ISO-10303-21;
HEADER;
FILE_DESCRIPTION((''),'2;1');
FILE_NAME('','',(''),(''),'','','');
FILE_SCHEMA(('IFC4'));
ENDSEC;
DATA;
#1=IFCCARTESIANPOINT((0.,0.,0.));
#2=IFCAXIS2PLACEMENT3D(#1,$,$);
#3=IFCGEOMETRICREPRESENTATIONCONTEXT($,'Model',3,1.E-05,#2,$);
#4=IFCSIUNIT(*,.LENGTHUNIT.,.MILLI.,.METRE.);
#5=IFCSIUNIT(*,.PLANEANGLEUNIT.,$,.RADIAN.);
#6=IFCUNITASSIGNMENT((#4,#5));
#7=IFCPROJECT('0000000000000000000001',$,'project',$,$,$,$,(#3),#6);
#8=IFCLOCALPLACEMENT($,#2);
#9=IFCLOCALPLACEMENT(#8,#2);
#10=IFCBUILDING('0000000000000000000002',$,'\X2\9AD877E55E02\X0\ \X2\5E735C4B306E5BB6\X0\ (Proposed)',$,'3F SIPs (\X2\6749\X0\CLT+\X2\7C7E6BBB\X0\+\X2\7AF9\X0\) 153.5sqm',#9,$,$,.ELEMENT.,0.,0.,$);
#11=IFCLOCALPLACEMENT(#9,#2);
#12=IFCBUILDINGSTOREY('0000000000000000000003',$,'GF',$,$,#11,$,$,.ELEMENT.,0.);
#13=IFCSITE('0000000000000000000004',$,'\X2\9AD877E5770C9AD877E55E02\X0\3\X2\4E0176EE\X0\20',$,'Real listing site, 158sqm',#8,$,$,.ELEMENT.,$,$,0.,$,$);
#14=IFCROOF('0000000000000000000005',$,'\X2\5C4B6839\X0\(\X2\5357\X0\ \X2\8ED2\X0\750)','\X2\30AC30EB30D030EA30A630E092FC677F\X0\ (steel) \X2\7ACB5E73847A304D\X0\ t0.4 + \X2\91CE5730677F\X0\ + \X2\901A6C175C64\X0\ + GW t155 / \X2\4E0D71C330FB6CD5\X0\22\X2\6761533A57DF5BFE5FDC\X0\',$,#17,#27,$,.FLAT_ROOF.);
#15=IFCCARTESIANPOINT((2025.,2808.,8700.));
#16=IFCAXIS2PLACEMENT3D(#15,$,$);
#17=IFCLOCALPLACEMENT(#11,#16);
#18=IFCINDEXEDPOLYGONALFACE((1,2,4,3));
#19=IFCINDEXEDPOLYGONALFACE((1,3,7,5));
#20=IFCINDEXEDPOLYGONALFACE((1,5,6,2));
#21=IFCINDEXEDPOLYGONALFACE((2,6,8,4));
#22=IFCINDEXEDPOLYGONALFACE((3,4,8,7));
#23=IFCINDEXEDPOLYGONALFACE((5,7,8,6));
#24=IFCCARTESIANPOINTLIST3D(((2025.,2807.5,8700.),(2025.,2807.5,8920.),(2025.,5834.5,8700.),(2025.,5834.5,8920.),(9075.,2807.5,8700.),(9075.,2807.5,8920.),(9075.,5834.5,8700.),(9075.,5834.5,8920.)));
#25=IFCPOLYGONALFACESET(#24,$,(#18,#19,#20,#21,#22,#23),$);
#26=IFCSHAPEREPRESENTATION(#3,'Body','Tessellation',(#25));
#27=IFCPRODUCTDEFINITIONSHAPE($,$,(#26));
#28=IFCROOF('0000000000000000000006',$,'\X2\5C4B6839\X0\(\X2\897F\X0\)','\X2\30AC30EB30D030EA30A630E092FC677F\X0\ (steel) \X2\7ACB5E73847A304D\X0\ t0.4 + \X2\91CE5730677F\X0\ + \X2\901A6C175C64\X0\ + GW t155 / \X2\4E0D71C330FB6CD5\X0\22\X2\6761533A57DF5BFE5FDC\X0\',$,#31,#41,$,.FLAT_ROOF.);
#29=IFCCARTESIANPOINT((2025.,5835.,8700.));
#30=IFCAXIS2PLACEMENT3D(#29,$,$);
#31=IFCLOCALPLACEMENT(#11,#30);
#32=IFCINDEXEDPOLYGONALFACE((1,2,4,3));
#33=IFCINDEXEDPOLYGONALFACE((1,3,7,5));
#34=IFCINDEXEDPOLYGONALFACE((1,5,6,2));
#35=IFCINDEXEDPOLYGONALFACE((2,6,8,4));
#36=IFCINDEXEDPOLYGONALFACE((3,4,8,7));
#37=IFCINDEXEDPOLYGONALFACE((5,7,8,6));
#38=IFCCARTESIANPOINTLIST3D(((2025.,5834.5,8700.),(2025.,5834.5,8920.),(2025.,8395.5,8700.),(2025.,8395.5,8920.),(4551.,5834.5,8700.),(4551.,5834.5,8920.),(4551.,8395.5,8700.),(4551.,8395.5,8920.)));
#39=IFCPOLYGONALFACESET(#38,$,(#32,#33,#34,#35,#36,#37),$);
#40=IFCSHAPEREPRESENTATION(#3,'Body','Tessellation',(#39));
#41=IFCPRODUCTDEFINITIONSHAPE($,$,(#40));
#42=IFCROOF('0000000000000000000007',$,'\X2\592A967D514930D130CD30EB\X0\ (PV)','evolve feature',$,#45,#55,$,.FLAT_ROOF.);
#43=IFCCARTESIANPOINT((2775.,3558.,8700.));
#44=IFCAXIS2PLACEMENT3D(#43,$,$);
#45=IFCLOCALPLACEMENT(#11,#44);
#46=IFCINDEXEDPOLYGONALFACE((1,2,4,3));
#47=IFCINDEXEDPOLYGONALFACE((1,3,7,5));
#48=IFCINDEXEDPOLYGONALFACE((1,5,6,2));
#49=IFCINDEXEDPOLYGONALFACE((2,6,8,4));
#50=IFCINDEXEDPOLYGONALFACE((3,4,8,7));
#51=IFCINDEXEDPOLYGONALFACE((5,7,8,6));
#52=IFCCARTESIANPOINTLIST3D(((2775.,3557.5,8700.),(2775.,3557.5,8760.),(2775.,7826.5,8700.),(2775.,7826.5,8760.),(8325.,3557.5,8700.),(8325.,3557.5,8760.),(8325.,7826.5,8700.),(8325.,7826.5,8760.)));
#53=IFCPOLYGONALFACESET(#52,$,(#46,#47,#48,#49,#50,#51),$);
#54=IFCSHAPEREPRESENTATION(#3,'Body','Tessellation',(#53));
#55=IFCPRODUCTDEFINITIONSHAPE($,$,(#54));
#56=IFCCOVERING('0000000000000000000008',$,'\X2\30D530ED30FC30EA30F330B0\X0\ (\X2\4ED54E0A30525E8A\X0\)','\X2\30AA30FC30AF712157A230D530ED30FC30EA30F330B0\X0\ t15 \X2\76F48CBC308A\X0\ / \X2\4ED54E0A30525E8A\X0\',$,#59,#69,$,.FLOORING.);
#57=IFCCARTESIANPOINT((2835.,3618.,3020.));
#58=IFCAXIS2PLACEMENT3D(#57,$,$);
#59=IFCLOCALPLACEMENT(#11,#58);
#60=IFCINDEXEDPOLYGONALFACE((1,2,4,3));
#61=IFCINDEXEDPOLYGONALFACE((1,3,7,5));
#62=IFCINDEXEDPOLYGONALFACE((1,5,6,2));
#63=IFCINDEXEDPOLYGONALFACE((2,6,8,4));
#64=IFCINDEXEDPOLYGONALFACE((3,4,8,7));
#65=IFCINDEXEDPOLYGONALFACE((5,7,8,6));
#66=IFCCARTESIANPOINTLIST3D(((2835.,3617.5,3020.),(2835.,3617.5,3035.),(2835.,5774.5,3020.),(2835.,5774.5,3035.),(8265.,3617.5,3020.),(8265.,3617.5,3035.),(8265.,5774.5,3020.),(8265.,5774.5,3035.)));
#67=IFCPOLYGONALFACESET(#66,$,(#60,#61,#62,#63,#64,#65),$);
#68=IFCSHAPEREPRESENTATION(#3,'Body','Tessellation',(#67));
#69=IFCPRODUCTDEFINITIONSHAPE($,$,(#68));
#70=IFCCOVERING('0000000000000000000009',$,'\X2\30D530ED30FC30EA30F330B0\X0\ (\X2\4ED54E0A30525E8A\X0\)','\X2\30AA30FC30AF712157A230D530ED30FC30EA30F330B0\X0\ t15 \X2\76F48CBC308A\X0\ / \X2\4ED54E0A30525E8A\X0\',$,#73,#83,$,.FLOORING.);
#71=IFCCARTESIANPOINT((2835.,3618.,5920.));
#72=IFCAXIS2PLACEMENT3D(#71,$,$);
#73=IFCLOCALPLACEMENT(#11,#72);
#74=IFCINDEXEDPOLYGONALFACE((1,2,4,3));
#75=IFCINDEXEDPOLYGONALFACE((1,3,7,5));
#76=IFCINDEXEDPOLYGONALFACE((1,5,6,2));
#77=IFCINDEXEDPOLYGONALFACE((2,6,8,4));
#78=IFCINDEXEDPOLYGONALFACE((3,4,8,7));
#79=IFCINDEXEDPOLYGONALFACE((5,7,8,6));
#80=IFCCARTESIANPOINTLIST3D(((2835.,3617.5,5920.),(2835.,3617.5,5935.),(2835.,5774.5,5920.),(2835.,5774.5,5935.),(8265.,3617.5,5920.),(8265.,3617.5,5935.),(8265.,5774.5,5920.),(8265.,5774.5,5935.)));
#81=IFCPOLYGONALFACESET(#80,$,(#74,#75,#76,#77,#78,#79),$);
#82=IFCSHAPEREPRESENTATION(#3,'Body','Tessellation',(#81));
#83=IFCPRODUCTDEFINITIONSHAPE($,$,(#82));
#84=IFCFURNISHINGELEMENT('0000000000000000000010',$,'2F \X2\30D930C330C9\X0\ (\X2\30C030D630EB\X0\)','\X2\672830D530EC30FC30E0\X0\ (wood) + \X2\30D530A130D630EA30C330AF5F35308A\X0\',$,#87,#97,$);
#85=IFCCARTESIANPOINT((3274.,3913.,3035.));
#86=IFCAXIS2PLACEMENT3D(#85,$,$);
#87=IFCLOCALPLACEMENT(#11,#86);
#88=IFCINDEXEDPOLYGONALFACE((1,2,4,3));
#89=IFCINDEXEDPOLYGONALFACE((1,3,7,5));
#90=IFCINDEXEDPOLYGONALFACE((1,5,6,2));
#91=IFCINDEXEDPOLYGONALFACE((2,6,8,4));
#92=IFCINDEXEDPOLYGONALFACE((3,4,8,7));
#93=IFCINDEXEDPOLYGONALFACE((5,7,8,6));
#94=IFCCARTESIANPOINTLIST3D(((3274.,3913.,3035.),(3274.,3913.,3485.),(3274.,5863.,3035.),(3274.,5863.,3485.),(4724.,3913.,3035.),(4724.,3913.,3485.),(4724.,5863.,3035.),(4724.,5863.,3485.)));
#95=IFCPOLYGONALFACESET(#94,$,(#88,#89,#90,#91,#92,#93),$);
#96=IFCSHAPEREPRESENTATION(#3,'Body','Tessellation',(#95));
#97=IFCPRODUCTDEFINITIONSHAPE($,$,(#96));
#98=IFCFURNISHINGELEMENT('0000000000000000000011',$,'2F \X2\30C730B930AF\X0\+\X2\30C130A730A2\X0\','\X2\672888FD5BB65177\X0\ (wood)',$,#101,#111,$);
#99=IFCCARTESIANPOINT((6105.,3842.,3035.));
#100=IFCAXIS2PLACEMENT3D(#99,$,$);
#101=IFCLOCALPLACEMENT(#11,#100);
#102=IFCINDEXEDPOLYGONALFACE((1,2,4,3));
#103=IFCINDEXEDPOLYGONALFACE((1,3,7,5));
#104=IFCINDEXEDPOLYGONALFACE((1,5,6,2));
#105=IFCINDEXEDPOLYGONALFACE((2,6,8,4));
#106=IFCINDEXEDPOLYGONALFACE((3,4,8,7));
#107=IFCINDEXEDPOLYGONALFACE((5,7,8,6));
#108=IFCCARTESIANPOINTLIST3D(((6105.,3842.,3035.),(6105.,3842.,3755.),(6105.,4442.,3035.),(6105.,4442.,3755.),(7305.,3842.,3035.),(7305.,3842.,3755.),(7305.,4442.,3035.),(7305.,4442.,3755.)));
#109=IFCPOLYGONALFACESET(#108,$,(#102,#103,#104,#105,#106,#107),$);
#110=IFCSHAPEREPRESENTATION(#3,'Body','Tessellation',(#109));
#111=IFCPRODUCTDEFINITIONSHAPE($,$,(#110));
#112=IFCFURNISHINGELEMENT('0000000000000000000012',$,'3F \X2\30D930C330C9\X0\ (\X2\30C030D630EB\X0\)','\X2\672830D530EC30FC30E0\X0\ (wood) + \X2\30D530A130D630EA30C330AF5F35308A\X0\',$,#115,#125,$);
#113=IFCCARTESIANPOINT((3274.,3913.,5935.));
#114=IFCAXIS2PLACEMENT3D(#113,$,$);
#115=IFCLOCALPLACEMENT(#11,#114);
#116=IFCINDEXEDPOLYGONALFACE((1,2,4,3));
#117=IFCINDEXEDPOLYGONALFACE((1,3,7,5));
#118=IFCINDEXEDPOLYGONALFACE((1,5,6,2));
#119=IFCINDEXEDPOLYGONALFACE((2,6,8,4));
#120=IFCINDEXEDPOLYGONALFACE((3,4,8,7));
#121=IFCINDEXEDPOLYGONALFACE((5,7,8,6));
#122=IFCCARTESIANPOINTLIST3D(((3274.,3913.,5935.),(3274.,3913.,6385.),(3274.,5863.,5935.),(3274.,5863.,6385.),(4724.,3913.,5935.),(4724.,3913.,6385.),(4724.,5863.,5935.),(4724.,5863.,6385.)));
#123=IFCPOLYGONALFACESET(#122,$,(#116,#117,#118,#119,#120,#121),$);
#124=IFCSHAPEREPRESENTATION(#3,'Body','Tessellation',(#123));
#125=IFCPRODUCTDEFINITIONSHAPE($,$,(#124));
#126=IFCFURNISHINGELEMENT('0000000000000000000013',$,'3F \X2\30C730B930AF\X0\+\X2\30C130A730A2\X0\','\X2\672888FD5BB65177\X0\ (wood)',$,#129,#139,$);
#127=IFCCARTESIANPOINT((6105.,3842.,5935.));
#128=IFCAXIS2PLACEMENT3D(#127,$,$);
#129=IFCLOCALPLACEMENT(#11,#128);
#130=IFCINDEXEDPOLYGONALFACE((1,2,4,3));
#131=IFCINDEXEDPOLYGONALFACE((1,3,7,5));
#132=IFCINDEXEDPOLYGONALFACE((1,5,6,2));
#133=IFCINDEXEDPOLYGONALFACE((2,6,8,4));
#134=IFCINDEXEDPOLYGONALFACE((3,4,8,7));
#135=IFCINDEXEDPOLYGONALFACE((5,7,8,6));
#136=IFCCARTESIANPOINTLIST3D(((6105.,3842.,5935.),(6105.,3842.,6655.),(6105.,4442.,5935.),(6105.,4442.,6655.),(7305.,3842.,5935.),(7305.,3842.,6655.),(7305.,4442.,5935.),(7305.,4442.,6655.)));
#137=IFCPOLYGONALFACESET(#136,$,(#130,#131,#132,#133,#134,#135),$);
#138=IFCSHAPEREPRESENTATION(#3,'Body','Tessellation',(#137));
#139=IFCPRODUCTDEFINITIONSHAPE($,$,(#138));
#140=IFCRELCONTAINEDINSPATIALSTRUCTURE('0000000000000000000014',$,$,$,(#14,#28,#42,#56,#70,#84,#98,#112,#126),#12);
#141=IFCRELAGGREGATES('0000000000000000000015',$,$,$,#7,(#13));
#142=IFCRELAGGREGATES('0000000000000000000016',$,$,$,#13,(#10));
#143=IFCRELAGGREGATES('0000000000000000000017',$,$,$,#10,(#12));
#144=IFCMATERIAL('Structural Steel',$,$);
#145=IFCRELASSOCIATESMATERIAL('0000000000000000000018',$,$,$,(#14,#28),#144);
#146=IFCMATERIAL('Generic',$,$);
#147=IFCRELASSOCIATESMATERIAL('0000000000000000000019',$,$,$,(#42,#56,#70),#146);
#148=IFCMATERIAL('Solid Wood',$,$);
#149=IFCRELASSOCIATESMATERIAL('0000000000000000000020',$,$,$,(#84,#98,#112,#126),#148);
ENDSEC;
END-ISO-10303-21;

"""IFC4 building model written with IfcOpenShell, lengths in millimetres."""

from ifc_helpers import new_model, si_unit, frame, frame_2d, origin, place, context, project, spatial, rectangle, extrude, material, element, save


model = new_model("IFC4")

# Units and contexts
model_context = context("Model", 3, precision=1e-05, world=origin())
ifc_project = project(units=[si_unit("LENGTHUNIT", "METRE", prefix="MILLI"), si_unit("PLANEANGLEUNIT", "RADIAN")], contexts=[model_context])

# Site, building, storey
site_placement = place(None, origin())
site = spatial("IfcSite", under=ifc_project, at=site_placement, Name="高知県高知市3丁目20", ObjectType="Real listing site, 158sqm", CompositionType="ELEMENT", RefElevation=0.0)
building_placement = place(site_placement, origin())
building = spatial("IfcBuilding", under=site, at=building_placement, Name="高知市 平屋の家 (Proposed)", ObjectType="3F SIPs (杉CLT+籾殻+竹) 153.5sqm", CompositionType="ELEMENT", ElevationOfRefHeight=0.0, ElevationOfTerrain=0.0)
storey_placement = place(building_placement, origin())
storey = spatial("IfcBuildingStorey", under=building, at=storey_placement, Name="GF", CompositionType="ELEMENT", Elevation=0.0)

# Shared definitions
ifc_material_1 = material(Name="Solid Wood")

# Roofs
ifc_material_2 = material(Name="Structural Steel")
roof_1_placement = place(storey_placement, frame((2025.0, 2808.0, 8700.0)))
element("IfcRoof", 1, at=roof_1_placement, inside=storey, material=ifc_material_2, Name="屋根(南 軒750)", Description="ガルバリウム鋼板 (steel) 立平葺き t0.4 + 野地板 + 通気層 + GW t155 / 不燃・法22条区域対応", PredefinedType="FLAT_ROOF", context=model_context, shape_type="SweptSolid", body=[
    extrude(rectangle(XDim=7050.0, YDim=3027.0, at=frame_2d((3525.0, 1513.0))), frame((2025.0, 2808.0, 8700.0)), (0.0, 0.0, 1.0), 220.0),
])
roof_2_placement = place(storey_placement, frame((2025.0, 5835.0, 8700.0)))
element("IfcRoof", 2, at=roof_2_placement, inside=storey, material=ifc_material_2, Name="屋根(西)", Description="ガルバリウム鋼板 (steel) 立平葺き t0.4 + 野地板 + 通気層 + GW t155 / 不燃・法22条区域対応", PredefinedType="FLAT_ROOF", context=model_context, shape_type="SweptSolid", body=[
    extrude(rectangle(XDim=2526.0, YDim=2561.0, at=frame_2d((1263.0, 1280.0))), frame((2025.0, 5835.0, 8700.0)), (0.0, 0.0, 1.0), 220.0),
])
ifc_material_3 = material(Name="Generic")
roof_3_placement = place(storey_placement, frame((2775.0, 3558.0, 8700.0)))
element("IfcRoof", 3, at=roof_3_placement, inside=storey, material=ifc_material_3, Name="太陽光パネル (PV)", Description="evolve feature", PredefinedType="FLAT_ROOF", context=model_context, shape_type="SweptSolid", body=[
    extrude(rectangle(XDim=5550.0, YDim=4269.0, at=frame_2d((2775.0, 2134.0))), frame((2775.0, 3558.0, 8700.0)), (0.0, 0.0, 1.0), 60.0),
])

# Coverings
covering_1_placement = place(storey_placement, frame((2835.0, 3618.0, 3020.0)))
element("IfcCovering", 4, at=covering_1_placement, inside=storey, material=ifc_material_3, Name="フローリング (仕上げ床)", Description="オーク無垢フローリング t15 直貼り / 仕上げ床", PredefinedType="FLOORING", context=model_context, shape_type="SweptSolid", body=[
    extrude(rectangle(XDim=5430.0, YDim=2157.0, at=frame_2d((2715.0, 1078.0))), frame((2835.0, 3618.0, 3020.0)), (0.0, 0.0, 1.0), 15.0),
])
covering_2_placement = place(storey_placement, frame((2835.0, 3618.0, 5920.0)))
element("IfcCovering", 5, at=covering_2_placement, inside=storey, material=ifc_material_3, Name="フローリング (仕上げ床)", Description="オーク無垢フローリング t15 直貼り / 仕上げ床", PredefinedType="FLOORING", context=model_context, shape_type="SweptSolid", body=[
    extrude(rectangle(XDim=5430.0, YDim=2157.0, at=frame_2d((2715.0, 1078.0))), frame((2835.0, 3618.0, 5920.0)), (0.0, 0.0, 1.0), 15.0),
])

# Furnishing elements
furnishing_1_placement = place(storey_placement, frame((3274.0, 3913.0, 3035.0)))
element("IfcFurnishingElement", 6, at=furnishing_1_placement, inside=storey, material=ifc_material_1, Name="2F ベッド (ダブル)", Description="木フレーム (wood) + ファブリック張り", context=model_context, shape_type="SweptSolid", body=[
    extrude(rectangle(XDim=1450.0, YDim=1950.0, at=frame_2d((725.0, 975.0))), frame((3274.0, 3913.0, 3035.0)), (0.0, 0.0, 1.0), 450.0),
])
furnishing_2_placement = place(storey_placement, frame((6105.0, 3842.0, 3035.0)))
element("IfcFurnishingElement", 7, at=furnishing_2_placement, inside=storey, material=ifc_material_1, Name="2F デスク+チェア", Description="木製家具 (wood)", context=model_context, shape_type="SweptSolid", body=[
    extrude(rectangle(XDim=1200.0, YDim=600.0, at=frame_2d((600.0, 300.0))), frame((6105.0, 3842.0, 3035.0)), (0.0, 0.0, 1.0), 720.0),
])
furnishing_3_placement = place(storey_placement, frame((3274.0, 3913.0, 5935.0)))
element("IfcFurnishingElement", 8, at=furnishing_3_placement, inside=storey, material=ifc_material_1, Name="3F ベッド (ダブル)", Description="木フレーム (wood) + ファブリック張り", context=model_context, shape_type="SweptSolid", body=[
    extrude(rectangle(XDim=1450.0, YDim=1950.0, at=frame_2d((725.0, 975.0))), frame((3274.0, 3913.0, 5935.0)), (0.0, 0.0, 1.0), 450.0),
])
furnishing_4_placement = place(storey_placement, frame((6105.0, 3842.0, 5935.0)))
element("IfcFurnishingElement", 9, at=furnishing_4_placement, inside=storey, material=ifc_material_1, Name="3F デスク+チェア", Description="木製家具 (wood)", context=model_context, shape_type="SweptSolid", body=[
    extrude(rectangle(XDim=1200.0, YDim=600.0, at=frame_2d((600.0, 300.0))), frame((6105.0, 3842.0, 5935.0)), (0.0, 0.0, 1.0), 720.0),
])

save(model, "model.ifc")
